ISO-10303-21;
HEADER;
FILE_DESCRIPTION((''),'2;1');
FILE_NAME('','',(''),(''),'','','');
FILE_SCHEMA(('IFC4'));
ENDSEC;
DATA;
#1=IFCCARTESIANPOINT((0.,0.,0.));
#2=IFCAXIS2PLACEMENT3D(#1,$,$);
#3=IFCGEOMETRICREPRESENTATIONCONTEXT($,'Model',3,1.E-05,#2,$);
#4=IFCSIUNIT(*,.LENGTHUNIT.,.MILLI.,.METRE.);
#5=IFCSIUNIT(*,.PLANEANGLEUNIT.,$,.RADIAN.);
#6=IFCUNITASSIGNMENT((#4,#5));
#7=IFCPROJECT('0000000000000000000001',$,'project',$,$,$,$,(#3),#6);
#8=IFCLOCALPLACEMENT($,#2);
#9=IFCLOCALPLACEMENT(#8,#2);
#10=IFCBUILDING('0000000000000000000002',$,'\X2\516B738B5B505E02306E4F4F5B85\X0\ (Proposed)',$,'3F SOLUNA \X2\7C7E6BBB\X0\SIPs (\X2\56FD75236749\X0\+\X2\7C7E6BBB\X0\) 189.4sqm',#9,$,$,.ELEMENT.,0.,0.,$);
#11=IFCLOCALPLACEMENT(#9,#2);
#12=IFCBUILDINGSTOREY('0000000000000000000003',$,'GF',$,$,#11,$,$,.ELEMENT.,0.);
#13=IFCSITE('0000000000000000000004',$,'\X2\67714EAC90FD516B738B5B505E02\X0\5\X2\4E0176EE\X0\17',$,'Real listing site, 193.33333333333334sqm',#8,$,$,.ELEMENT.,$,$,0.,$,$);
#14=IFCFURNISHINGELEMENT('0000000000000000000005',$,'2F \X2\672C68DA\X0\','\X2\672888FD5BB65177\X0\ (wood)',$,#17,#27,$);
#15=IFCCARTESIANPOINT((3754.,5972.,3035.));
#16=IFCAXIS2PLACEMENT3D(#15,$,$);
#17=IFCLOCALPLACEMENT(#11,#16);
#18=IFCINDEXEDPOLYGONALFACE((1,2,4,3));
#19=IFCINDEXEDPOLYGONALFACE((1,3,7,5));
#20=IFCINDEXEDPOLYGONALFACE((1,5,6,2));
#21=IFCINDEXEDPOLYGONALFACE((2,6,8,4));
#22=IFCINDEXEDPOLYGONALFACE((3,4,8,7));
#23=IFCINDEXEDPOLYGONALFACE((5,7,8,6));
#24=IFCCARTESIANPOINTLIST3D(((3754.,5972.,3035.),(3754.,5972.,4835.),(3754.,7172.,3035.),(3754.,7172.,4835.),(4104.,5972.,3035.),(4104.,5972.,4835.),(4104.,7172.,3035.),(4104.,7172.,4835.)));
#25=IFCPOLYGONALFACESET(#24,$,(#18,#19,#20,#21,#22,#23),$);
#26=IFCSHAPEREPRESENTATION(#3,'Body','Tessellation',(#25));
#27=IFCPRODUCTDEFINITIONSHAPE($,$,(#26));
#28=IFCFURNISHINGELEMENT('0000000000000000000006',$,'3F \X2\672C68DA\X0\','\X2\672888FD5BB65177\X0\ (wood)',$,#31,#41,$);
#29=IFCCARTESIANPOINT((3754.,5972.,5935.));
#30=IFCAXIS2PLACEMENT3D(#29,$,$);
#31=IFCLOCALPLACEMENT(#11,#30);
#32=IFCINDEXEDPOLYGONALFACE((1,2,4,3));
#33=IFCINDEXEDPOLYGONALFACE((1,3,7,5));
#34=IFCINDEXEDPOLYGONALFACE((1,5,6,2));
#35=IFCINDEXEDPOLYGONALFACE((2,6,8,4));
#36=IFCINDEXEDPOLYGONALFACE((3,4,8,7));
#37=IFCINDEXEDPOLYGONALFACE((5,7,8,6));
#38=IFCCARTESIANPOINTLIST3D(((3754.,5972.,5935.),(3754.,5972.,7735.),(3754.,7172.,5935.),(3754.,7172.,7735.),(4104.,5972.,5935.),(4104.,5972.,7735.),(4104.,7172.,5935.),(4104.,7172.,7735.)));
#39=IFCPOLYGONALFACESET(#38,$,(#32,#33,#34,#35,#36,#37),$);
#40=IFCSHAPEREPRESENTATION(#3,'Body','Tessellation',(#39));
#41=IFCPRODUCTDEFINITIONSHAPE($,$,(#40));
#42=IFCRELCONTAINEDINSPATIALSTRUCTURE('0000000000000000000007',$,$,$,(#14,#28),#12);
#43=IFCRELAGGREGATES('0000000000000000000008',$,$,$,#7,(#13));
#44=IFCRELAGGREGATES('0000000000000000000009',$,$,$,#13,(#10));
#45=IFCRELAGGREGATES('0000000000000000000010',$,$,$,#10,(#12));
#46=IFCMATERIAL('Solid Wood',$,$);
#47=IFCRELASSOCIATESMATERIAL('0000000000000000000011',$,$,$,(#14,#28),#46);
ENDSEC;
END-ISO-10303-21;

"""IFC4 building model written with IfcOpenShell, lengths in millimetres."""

from ifc_helpers import new_model, si_unit, frame, frame_2d, origin, place, context, project, spatial, rectangle, extrude, material, element, save


model = new_model("IFC4")

# Units and contexts
model_context = context("Model", 3, precision=1e-05, world=origin())
ifc_project = project(units=[si_unit("LENGTHUNIT", "METRE", prefix="MILLI"), si_unit("PLANEANGLEUNIT", "RADIAN")], contexts=[model_context])

# Site, building, storey
site_placement = place(None, origin())
site = spatial("IfcSite", under=ifc_project, at=site_placement, Name="東京都八王子市5丁目17", ObjectType="Real listing site, 193.33333333333334sqm", CompositionType="ELEMENT", RefElevation=0.0)
building_placement = place(site_placement, origin())
building = spatial("IfcBuilding", under=site, at=building_placement, Name="八王子市の住宅 (Proposed)", ObjectType="3F SOLUNA 籾殻SIPs (国産杉+籾殻) 189.4sqm", CompositionType="ELEMENT", ElevationOfRefHeight=0.0, ElevationOfTerrain=0.0)
storey_placement = place(building_placement, origin())
storey = spatial("IfcBuildingStorey", under=building, at=storey_placement, Name="GF", CompositionType="ELEMENT", Elevation=0.0)

# Shared definitions
ifc_material_1 = material(Name="Solid Wood")

# Furnishing elements
furnishing_1_placement = place(storey_placement, frame((3754.0, 5972.0, 3035.0)))
element("IfcFurnishingElement", 1, at=furnishing_1_placement, inside=storey, material=ifc_material_1, Name="2F 本棚", Description="木製家具 (wood)", context=model_context, shape_type="SweptSolid", body=[
    extrude(rectangle(XDim=350.0, YDim=1200.0, at=frame_2d((175.0, 600.0))), frame((3754.0, 5972.0, 3035.0)), (0.0, 0.0, 1.0), 1800.0),
])
furnishing_2_placement = place(storey_placement, frame((3754.0, 5972.0, 5935.0)))
element("IfcFurnishingElement", 2, at=furnishing_2_placement, inside=storey, material=ifc_material_1, Name="3F 本棚", Description="木製家具 (wood)", context=model_context, shape_type="SweptSolid", body=[
    extrude(rectangle(XDim=350.0, YDim=1200.0, at=frame_2d((175.0, 600.0))), frame((3754.0, 5972.0, 5935.0)), (0.0, 0.0, 1.0), 1800.0),
])

save(model, "model.ifc")
